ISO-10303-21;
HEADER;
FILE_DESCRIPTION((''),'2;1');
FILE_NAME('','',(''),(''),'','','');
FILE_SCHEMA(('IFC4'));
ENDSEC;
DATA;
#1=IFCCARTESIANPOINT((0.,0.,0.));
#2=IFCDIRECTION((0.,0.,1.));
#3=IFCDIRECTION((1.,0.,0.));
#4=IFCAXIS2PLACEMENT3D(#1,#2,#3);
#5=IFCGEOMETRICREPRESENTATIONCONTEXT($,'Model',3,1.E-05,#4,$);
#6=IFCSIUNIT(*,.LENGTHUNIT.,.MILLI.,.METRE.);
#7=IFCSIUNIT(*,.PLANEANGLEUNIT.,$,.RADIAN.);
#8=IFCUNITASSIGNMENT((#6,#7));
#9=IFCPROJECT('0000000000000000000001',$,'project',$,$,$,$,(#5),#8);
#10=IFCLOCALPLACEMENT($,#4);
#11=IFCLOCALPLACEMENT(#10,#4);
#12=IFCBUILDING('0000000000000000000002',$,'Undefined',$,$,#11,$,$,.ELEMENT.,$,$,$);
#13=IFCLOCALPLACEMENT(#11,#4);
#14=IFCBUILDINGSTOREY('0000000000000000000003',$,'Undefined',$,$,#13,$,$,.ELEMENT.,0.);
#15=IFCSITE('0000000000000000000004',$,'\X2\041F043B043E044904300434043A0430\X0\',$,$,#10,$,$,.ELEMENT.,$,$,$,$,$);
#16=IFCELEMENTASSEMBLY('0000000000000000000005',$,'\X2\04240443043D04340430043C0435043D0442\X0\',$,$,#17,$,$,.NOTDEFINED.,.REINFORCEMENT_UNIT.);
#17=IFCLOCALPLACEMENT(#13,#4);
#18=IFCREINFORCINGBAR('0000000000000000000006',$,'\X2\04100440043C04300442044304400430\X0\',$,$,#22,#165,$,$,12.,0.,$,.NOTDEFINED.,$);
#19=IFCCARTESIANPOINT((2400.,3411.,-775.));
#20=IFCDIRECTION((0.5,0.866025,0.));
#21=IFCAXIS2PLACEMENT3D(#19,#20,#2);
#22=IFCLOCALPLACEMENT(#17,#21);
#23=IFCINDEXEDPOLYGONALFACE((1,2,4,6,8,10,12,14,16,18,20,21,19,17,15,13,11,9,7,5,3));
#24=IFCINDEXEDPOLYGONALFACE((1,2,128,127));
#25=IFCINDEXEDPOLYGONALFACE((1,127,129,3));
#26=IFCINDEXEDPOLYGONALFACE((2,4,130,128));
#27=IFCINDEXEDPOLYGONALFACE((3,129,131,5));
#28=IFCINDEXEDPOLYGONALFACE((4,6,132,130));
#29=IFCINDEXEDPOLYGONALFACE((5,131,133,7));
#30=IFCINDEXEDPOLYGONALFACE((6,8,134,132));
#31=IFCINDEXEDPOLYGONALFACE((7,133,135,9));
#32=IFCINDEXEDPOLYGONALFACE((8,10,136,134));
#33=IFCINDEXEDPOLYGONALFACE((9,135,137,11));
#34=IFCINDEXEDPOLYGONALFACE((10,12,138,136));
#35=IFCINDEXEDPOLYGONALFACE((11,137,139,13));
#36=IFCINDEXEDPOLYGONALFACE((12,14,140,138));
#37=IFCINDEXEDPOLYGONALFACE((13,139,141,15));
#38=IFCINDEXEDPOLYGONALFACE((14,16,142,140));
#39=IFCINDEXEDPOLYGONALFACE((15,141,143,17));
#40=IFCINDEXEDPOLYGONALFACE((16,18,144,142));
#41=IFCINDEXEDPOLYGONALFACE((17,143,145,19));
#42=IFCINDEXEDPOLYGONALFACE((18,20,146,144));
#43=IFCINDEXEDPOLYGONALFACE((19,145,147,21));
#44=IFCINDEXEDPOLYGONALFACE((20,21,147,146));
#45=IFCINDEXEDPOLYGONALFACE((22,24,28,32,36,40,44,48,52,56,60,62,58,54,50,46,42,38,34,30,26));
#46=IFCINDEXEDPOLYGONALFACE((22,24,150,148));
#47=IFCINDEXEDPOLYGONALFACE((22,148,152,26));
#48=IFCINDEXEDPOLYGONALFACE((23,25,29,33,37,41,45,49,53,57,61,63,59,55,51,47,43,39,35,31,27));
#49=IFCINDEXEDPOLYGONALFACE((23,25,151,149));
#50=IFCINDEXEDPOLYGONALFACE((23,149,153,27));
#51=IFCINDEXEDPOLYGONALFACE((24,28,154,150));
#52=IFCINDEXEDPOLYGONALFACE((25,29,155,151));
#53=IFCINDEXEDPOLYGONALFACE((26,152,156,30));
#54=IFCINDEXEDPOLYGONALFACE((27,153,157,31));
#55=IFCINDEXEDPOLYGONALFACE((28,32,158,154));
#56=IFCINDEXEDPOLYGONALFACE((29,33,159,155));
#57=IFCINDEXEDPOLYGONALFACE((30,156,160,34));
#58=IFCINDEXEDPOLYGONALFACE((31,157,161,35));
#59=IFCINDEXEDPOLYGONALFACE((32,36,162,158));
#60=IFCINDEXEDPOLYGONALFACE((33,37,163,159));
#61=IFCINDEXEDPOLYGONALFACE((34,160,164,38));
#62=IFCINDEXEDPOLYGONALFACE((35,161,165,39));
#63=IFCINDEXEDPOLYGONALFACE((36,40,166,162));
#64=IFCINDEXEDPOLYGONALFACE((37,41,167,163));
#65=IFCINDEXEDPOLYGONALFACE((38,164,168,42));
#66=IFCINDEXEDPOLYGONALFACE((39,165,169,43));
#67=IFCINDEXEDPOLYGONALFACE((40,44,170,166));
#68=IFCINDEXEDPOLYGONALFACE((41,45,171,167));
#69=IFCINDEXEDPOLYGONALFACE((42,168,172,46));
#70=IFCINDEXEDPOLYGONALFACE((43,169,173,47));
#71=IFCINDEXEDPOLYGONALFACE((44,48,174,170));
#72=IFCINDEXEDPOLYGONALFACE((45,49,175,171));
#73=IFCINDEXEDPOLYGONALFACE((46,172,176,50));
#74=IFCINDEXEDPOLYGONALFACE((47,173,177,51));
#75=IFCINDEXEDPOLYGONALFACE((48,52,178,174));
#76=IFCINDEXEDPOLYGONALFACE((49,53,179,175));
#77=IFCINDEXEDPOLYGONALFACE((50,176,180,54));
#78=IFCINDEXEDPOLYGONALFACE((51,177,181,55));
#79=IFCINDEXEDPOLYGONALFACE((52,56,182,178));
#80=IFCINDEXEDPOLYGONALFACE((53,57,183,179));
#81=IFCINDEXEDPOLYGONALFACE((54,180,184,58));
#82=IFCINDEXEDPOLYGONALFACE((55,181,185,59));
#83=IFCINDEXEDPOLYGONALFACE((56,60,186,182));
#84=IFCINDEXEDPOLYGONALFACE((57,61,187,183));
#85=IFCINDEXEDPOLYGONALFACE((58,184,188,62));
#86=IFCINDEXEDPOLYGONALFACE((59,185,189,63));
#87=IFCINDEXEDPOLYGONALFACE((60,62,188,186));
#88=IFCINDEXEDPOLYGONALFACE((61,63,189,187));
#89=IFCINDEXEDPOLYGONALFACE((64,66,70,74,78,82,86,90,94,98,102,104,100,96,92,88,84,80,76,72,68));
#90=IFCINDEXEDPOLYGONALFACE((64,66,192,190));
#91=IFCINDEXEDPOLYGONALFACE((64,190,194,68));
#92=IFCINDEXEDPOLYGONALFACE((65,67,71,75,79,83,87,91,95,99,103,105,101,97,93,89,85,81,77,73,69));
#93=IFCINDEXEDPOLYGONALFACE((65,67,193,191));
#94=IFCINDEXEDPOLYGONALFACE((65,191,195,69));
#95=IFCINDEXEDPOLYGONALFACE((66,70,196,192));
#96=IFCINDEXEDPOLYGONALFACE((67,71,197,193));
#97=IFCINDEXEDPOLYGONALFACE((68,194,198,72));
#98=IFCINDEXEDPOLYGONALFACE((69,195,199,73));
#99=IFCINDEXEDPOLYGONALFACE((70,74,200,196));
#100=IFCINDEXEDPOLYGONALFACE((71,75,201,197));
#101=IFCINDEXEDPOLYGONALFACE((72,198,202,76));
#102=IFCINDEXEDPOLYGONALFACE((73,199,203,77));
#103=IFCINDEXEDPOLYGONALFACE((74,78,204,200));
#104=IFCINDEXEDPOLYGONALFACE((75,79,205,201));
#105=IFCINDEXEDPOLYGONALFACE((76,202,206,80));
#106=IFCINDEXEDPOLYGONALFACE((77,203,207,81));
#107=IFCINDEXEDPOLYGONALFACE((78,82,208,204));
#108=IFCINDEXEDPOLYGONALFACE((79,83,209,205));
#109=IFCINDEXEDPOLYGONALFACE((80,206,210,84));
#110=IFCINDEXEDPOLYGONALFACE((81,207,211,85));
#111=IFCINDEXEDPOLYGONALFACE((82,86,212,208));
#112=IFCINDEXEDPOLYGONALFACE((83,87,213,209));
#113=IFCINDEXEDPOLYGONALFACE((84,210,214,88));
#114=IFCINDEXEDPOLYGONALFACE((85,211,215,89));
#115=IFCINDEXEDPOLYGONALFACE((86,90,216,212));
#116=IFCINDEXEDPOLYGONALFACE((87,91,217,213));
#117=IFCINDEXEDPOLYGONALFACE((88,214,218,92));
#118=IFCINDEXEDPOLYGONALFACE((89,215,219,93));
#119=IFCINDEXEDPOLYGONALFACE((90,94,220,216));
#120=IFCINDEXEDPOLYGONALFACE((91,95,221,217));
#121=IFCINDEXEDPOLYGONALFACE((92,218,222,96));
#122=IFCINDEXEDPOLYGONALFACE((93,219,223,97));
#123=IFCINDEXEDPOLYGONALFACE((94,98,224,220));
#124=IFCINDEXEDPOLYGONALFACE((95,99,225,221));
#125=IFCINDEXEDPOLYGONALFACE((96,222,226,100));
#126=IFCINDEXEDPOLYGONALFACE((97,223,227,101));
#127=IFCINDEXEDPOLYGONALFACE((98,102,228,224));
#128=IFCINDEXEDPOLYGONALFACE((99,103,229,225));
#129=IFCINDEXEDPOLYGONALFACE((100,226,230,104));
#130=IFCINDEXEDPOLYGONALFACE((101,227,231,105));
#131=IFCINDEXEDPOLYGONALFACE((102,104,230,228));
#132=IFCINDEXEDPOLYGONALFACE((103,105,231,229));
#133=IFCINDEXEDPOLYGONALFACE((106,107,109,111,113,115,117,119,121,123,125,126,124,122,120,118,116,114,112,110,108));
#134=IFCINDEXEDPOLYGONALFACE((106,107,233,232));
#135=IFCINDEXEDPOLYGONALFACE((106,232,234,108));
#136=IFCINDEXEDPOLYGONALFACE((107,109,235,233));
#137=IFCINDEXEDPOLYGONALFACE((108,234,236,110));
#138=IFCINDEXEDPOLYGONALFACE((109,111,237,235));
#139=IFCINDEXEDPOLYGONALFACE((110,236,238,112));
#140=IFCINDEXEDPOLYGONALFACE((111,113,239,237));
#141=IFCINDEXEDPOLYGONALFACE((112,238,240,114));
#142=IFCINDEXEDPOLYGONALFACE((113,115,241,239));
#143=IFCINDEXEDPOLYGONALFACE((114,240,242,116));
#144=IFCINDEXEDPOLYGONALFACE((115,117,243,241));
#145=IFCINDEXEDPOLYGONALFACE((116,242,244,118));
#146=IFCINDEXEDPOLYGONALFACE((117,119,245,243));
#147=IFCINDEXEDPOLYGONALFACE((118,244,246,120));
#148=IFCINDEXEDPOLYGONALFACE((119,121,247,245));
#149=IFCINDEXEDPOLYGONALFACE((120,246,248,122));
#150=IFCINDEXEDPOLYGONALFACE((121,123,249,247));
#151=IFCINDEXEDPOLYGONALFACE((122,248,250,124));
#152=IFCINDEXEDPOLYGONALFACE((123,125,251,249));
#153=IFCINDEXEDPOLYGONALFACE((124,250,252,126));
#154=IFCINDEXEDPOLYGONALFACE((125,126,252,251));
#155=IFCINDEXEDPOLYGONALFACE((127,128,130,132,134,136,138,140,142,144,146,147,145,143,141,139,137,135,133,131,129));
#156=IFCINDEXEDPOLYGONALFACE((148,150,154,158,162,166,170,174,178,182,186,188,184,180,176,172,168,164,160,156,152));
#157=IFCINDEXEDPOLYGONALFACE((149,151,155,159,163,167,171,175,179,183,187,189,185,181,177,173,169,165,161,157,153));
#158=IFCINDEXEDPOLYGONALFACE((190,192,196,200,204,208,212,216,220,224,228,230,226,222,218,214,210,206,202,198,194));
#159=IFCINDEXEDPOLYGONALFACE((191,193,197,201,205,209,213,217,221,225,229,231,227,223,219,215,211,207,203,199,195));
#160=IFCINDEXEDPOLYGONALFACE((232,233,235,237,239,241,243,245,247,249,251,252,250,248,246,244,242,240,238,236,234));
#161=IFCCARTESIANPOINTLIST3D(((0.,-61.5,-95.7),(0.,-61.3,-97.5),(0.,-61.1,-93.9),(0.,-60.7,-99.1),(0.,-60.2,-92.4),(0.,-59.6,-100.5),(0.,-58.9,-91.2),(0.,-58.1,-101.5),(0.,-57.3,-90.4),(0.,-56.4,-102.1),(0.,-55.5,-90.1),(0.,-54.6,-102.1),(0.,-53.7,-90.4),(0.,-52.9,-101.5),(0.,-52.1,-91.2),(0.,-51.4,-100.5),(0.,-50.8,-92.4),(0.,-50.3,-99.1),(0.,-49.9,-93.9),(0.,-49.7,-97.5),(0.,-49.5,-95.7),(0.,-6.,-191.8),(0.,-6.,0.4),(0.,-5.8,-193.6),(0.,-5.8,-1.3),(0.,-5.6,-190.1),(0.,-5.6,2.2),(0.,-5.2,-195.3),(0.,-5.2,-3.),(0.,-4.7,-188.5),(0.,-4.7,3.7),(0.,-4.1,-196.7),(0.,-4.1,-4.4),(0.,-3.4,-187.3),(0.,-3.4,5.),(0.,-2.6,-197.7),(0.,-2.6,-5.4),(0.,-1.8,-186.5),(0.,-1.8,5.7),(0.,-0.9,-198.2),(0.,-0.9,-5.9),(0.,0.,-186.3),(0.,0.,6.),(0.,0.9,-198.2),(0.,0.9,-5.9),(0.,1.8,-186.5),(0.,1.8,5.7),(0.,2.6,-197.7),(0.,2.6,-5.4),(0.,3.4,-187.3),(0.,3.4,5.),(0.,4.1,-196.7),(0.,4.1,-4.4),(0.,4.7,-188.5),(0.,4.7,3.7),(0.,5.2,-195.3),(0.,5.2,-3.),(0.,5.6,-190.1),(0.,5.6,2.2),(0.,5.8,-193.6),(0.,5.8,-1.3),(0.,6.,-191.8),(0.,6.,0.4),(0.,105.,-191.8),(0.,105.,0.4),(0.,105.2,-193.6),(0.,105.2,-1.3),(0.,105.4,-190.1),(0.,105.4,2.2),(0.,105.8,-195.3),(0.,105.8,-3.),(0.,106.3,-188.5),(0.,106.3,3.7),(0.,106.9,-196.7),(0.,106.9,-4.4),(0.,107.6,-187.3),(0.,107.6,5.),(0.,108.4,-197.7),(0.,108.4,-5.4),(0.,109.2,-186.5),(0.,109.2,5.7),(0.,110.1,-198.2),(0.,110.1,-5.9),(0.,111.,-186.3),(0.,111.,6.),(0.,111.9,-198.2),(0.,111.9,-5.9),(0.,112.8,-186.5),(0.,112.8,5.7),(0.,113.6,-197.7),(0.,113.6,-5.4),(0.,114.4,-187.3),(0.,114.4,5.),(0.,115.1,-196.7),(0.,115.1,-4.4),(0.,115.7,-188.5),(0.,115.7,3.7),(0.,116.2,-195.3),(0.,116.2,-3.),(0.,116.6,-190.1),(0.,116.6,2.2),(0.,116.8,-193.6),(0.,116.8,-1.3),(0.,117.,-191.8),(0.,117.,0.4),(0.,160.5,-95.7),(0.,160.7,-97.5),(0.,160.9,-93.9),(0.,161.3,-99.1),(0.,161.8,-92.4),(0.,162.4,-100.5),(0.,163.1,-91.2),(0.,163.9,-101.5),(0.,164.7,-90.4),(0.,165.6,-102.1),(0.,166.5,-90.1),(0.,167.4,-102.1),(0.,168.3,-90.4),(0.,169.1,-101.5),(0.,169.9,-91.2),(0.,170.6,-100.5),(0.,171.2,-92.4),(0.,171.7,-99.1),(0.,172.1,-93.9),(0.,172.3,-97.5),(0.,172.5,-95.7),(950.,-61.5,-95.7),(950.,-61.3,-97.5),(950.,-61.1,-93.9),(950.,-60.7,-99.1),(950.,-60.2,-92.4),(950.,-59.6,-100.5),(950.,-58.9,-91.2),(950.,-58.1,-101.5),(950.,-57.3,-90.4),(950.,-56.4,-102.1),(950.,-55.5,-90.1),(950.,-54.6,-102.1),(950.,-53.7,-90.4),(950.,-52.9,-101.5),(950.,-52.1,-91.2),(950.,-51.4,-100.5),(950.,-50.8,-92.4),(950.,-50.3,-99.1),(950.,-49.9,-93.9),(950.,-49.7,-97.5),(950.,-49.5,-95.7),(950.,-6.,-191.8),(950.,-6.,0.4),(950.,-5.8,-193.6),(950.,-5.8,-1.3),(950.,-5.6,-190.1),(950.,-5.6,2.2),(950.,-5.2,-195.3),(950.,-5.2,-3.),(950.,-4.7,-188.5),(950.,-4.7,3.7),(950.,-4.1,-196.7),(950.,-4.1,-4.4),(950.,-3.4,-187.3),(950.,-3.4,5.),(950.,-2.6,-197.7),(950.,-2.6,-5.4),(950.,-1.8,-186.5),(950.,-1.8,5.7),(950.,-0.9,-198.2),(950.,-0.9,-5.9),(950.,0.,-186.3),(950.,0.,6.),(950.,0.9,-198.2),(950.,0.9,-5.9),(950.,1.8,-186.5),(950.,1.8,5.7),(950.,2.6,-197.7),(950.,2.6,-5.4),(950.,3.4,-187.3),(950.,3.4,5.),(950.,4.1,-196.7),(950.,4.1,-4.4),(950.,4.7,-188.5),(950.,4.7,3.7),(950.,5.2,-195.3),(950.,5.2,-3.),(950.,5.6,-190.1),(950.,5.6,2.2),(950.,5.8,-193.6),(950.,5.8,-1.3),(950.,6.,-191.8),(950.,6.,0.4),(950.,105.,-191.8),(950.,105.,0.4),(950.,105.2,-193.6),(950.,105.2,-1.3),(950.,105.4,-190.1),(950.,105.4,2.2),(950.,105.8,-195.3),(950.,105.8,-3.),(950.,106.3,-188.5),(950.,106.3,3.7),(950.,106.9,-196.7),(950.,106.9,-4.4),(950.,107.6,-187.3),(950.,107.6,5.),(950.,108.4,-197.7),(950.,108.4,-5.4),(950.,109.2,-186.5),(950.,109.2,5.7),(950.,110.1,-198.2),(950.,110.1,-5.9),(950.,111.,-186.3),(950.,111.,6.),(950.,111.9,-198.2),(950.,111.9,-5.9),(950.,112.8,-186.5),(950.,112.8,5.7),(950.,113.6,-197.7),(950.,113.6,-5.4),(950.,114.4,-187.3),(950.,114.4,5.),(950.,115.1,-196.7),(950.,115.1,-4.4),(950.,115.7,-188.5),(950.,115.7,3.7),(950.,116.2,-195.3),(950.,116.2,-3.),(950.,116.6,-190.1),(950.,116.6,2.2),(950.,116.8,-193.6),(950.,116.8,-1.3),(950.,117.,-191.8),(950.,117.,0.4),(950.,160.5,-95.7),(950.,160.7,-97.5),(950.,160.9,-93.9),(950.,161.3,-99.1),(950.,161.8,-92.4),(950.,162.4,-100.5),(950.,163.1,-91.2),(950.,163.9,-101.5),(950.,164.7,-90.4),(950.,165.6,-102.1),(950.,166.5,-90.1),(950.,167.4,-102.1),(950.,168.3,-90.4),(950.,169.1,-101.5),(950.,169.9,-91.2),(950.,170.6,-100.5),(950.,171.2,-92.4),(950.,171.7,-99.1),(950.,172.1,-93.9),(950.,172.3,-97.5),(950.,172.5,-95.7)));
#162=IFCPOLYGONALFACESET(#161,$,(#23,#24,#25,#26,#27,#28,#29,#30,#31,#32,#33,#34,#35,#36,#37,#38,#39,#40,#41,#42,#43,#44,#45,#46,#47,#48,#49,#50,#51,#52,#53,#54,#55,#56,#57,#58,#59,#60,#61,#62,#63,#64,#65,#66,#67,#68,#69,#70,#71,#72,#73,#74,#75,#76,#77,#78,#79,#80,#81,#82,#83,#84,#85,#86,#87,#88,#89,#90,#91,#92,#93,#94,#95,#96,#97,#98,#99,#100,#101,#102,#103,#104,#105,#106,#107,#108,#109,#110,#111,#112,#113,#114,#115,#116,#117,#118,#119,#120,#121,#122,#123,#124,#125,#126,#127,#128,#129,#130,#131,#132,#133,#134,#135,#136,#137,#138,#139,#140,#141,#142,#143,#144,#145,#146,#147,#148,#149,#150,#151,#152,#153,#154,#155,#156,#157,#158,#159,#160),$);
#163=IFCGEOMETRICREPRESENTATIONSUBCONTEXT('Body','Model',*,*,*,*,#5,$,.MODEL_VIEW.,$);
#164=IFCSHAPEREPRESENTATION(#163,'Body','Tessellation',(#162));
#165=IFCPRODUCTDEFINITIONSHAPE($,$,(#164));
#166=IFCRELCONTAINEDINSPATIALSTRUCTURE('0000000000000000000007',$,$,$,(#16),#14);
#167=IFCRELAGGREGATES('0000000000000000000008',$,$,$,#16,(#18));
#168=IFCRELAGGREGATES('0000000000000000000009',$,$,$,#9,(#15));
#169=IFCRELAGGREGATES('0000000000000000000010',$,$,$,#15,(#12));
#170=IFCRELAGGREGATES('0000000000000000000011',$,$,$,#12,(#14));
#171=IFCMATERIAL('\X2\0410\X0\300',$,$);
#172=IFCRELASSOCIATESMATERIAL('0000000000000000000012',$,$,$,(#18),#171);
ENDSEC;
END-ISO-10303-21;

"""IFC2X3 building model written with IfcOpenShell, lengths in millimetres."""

from ifc_helpers import new_model, entity, si_unit, frame, origin_with_axes, place, context, subcontext, project, spatial, source, transform, mapped, material, element, aggregate, save


model = new_model("IFC2X3")

# Units and contexts
model_context = context("Model", 3, precision=1e-05, world=origin_with_axes())
body_context = subcontext(model_context, "Body", "Model", "MODEL_VIEW")
ifc_project = project(units=[si_unit("LENGTHUNIT", "METRE", prefix="MILLI"), si_unit("PLANEANGLEUNIT", "RADIAN")], contexts=[model_context])

# Site, building, storey
site_placement = place(None, origin_with_axes())
site = spatial("IfcSite", under=ifc_project, at=site_placement, Name="Площадка", CompositionType="ELEMENT")
building_placement = place(site_placement, origin_with_axes())
building = spatial("IfcBuilding", under=site, at=building_placement, Name="Undefined", CompositionType="ELEMENT")
storey_placement = place(building_placement, origin_with_axes())
storey = spatial("IfcBuildingStorey", under=building, at=storey_placement, Name="Undefined", CompositionType="ELEMENT", Elevation=0.0)

# Element assembly
assembly_1_placement = place(storey_placement, origin_with_axes())
assembly_1 = element("IfcElementAssembly", 1, at=assembly_1_placement, inside=storey, Name="Фундамент", AssemblyPlace="NOTDEFINED", PredefinedType="REINFORCEMENT_UNIT")

# Reinforcing bar
ifc_material_1 = material(Name="А300")
shared_shape_1 = source(origin_with_axes(), body_context, "Body", "AdvancedSweptSolid", [
    entity("IfcSweptDiskSolid", entity("IfcTrimmedCurve", entity("IfcLine", entity("IfcCartesianPoint", [0.0, 0.0, 0.0]), entity("IfcVector", entity("IfcDirection", [1.0, 0.0, 0.0]), 1.0)), [entity("IfcParameterValue", 0.0)], [entity("IfcParameterValue", 950.0)], True, "PARAMETER"), 6.0, None, 0.0, 950.0),
])
shared_shape_2 = source(origin_with_axes(), body_context, "Body", "AdvancedSweptSolid", [
    entity("IfcSweptDiskSolid", entity("IfcTrimmedCurve", entity("IfcLine", entity("IfcCartesianPoint", [0.0, 0.0, 0.0]), entity("IfcVector", entity("IfcDirection", [1.0, 0.0, 0.0]), 1.0)), [entity("IfcParameterValue", 0.0)], [entity("IfcParameterValue", 950.0)], True, "PARAMETER"), 6.0, None, 0.0, 950.0),
])
shared_shape_3 = source(origin_with_axes(), body_context, "Body", "AdvancedSweptSolid", [
    entity("IfcSweptDiskSolid", entity("IfcTrimmedCurve", entity("IfcLine", entity("IfcCartesianPoint", [0.0, 0.0, 0.0]), entity("IfcVector", entity("IfcDirection", [1.0, 0.0, 0.0]), 1.0)), [entity("IfcParameterValue", 0.0)], [entity("IfcParameterValue", 950.0)], True, "PARAMETER"), 6.0, None, 0.0, 950.0),
])
shared_shape_4 = source(origin_with_axes(), body_context, "Body", "AdvancedSweptSolid", [
    entity("IfcSweptDiskSolid", entity("IfcTrimmedCurve", entity("IfcLine", entity("IfcCartesianPoint", [0.0, 0.0, 0.0]), entity("IfcVector", entity("IfcDirection", [1.0, 0.0, 0.0]), 1.0)), [entity("IfcParameterValue", 0.0)], [entity("IfcParameterValue", 950.0)], True, "PARAMETER"), 6.0, None, 0.0, 950.0),
])
shared_shape_5 = source(origin_with_axes(), body_context, "Body", "AdvancedSweptSolid", [
    entity("IfcSweptDiskSolid", entity("IfcTrimmedCurve", entity("IfcLine", entity("IfcCartesianPoint", [0.0, 0.0, 0.0]), entity("IfcVector", entity("IfcDirection", [1.0, 0.0, 0.0]), 1.0)), [entity("IfcParameterValue", 0.0)], [entity("IfcParameterValue", 950.0)], True, "PARAMETER"), 6.0, None, 0.0, 950.0),
])
shared_shape_6 = source(origin_with_axes(), body_context, "Body", "AdvancedSweptSolid", [
    entity("IfcSweptDiskSolid", entity("IfcTrimmedCurve", entity("IfcLine", entity("IfcCartesianPoint", [0.0, 0.0, 0.0]), entity("IfcVector", entity("IfcDirection", [1.0, 0.0, 0.0]), 1.0)), [entity("IfcParameterValue", 0.0)], [entity("IfcParameterValue", 950.0)], True, "PARAMETER"), 6.0, None, 0.0, 950.0),
])
reinforcing_bar_1_placement = place(assembly_1_placement, frame((2400.0, 3411.0, -775.0), z_axis=(0.5, 0.866025, 0.0), x_axis=(0.0, 0.0, 1.0)))
reinforcing_bar_1 = element("IfcReinforcingBar", 2, at=reinforcing_bar_1_placement, material=ifc_material_1, Name="Арматура", BarRole="NOTDEFINED", CrossSectionArea=0.0, NominalDiameter=12.0, context=body_context, shape_type="MappedRepresentation", body=[
    mapped(shared_shape_1, transform((0.0, 0.0, 0.0))),
    mapped(shared_shape_2, transform((0.0, -55.5, -96.1))),
    mapped(shared_shape_3, transform((0.0, 0.0, -192.3))),
    mapped(shared_shape_4, transform((0.0, 111.0, -192.3))),
    mapped(shared_shape_5, transform((0.0, 166.5, -96.1))),
    mapped(shared_shape_6, transform((0.0, 111.0, 0.0))),
])
aggregate(assembly_1, [reinforcing_bar_1])

save(model, "model.ifc")
